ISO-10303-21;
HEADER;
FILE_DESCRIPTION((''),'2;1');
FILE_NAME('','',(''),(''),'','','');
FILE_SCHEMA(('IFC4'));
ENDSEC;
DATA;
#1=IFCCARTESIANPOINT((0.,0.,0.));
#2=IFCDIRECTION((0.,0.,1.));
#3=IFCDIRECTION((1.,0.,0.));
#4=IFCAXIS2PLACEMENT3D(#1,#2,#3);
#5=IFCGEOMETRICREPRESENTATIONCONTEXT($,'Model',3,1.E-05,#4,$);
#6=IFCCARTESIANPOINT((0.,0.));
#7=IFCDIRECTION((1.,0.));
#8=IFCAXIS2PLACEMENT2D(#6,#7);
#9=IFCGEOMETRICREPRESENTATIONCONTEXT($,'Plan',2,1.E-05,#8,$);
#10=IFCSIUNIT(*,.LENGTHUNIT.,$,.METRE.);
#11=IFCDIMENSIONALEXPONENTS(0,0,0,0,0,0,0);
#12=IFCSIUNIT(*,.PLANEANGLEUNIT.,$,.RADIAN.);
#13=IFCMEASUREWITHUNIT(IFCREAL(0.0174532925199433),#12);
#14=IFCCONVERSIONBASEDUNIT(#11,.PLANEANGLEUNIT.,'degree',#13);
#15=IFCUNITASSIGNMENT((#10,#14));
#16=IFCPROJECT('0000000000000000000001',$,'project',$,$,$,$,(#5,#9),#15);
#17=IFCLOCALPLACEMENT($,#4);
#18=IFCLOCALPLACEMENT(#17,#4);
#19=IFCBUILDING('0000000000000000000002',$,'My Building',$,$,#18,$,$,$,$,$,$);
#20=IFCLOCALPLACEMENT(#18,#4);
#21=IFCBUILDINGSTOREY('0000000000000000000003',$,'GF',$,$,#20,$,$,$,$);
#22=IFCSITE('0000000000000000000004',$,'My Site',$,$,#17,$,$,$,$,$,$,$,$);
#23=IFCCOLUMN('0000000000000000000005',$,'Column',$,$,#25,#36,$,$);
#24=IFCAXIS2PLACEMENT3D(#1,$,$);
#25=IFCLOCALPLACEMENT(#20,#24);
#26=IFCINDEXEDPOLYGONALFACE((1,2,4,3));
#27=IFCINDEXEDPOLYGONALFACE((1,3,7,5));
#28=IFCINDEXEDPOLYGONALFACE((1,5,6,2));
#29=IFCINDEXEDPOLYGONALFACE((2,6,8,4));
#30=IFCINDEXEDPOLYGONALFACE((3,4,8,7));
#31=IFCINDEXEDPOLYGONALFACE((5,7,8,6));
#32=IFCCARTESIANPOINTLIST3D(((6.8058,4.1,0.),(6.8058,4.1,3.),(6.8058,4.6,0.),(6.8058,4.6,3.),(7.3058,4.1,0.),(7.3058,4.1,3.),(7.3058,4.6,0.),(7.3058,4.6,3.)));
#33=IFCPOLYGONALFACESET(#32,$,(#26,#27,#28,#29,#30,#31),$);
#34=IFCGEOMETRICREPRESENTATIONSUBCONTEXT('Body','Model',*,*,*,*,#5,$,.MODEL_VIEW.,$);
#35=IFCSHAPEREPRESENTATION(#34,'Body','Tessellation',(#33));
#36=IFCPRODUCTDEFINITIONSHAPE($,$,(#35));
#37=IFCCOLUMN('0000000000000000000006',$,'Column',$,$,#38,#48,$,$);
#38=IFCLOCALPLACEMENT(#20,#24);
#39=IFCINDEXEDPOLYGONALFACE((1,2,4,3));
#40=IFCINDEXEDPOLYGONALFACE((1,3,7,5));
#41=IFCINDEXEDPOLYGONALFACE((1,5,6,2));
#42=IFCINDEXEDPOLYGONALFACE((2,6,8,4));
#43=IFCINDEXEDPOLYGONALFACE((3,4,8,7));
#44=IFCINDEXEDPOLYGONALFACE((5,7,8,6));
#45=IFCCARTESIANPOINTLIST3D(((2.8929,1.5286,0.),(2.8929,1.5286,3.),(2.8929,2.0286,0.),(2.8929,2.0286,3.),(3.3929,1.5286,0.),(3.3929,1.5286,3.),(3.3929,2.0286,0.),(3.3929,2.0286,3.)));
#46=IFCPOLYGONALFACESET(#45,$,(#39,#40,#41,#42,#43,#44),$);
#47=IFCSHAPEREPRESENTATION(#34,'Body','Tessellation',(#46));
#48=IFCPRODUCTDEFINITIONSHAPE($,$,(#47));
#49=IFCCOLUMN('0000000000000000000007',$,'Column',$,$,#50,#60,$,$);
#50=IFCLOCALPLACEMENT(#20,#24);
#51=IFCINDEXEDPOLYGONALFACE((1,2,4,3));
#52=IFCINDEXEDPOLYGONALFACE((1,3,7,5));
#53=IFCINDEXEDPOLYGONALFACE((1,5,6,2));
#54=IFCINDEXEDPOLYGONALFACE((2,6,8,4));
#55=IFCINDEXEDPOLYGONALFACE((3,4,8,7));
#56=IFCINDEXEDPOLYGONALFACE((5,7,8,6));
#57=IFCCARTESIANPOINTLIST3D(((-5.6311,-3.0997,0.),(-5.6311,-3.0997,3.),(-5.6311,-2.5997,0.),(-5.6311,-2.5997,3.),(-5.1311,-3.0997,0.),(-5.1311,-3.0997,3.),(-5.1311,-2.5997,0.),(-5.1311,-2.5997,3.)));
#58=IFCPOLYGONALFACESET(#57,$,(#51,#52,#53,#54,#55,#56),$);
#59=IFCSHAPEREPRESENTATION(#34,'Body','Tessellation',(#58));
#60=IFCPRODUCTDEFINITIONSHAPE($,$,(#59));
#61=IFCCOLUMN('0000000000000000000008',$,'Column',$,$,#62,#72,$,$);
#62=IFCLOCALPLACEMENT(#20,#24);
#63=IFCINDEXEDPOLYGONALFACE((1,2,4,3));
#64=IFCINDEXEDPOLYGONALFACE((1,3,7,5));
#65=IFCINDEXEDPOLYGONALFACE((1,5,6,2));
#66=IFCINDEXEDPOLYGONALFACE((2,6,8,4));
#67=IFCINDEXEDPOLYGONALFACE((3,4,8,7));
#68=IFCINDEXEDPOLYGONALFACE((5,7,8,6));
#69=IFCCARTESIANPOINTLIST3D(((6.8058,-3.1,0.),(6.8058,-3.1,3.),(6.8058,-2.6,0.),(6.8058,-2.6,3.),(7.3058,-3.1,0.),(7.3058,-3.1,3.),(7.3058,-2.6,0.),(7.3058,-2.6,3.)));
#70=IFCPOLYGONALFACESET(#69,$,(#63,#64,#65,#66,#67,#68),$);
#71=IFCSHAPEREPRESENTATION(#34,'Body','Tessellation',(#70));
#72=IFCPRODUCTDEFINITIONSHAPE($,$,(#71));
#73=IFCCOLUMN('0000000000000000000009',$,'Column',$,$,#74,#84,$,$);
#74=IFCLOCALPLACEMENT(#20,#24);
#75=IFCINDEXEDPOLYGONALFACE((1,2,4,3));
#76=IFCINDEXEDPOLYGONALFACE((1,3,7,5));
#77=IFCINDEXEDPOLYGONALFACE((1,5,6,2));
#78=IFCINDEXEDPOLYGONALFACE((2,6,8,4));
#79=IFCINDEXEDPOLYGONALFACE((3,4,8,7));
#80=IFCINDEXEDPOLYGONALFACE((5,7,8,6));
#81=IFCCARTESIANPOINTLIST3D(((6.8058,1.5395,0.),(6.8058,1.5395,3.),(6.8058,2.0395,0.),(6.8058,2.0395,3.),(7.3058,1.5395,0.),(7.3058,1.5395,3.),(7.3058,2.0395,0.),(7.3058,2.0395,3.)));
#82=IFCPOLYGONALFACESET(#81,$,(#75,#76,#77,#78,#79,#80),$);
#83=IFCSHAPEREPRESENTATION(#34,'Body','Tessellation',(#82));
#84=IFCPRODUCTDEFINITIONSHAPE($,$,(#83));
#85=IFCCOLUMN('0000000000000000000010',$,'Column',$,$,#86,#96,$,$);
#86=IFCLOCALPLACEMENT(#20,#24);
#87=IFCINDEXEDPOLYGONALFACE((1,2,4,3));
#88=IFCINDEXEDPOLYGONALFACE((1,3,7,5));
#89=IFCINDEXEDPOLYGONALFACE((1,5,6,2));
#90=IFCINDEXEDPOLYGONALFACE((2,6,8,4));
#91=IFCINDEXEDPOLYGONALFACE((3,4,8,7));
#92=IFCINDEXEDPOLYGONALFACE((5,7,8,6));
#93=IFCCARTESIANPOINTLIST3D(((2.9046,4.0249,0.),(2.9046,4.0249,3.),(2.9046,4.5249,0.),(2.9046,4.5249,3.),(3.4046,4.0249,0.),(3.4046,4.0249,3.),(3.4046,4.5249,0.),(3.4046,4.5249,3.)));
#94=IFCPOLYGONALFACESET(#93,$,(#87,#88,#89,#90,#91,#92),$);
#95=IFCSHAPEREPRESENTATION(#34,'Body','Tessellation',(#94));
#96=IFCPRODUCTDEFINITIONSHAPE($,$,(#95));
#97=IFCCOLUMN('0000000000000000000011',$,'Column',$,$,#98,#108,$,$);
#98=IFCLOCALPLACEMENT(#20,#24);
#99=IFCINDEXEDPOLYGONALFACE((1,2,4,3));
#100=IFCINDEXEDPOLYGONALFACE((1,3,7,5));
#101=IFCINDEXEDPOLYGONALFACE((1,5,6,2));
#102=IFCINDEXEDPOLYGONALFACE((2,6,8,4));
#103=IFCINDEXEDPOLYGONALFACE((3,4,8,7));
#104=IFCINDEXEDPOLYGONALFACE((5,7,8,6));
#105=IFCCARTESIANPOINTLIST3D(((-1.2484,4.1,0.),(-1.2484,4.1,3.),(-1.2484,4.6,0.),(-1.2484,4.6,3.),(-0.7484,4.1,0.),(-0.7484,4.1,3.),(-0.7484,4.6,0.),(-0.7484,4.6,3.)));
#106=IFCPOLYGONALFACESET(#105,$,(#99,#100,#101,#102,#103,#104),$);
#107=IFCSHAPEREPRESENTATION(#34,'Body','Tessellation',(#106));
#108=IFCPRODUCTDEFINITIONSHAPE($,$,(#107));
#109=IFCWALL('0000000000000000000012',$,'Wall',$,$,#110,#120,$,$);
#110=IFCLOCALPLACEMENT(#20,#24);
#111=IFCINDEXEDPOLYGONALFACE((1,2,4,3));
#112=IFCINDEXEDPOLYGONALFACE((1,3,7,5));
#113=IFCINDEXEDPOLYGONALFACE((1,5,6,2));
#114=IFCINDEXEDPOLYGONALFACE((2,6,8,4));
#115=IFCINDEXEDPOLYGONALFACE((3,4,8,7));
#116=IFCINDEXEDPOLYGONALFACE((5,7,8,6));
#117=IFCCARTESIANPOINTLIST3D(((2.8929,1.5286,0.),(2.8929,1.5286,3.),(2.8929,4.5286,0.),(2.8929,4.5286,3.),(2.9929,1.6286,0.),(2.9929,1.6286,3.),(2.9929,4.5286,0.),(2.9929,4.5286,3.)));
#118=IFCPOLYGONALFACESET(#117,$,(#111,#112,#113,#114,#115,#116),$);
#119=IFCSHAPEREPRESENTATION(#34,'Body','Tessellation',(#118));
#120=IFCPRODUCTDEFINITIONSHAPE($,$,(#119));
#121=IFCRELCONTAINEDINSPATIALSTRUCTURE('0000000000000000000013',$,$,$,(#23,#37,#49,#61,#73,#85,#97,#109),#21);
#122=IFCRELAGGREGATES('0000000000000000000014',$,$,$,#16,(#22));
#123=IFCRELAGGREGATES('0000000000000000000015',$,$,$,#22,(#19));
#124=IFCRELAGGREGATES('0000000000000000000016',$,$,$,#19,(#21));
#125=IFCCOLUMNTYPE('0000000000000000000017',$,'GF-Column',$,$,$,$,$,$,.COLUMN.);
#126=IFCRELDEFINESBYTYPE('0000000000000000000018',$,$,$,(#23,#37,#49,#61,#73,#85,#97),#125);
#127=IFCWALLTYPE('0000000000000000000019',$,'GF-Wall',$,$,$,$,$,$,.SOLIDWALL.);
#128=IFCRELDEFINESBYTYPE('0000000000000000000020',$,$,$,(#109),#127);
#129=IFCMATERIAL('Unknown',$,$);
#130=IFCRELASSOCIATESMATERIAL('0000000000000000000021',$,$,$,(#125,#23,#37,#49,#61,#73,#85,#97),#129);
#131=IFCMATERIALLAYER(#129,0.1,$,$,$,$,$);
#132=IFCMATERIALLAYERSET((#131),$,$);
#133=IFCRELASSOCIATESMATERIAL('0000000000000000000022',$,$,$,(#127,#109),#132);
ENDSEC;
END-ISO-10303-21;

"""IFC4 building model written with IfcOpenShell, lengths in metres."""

from ifc_helpers import new_model, entity, si_unit, converted_unit, frame, origin_with_axes, origin_2d_with_axis, place, context, subcontext, project, spatial, line, indexed_curve, rectangle, outline, extrude, material, layer, layer_set, layer_usage, material_profile, profile_set, profile_usage, type_object, element, save


model = new_model("IFC4")

# Units and contexts
model_context = context("Model", 3, precision=1e-05, world=origin_with_axes())
plan_context = context("Plan", 2, precision=1e-05, world=origin_2d_with_axis())
body_context_1 = subcontext(model_context, "Body", "Model", "MODEL_VIEW")
ifc_project = project(units=[si_unit("LENGTHUNIT", "METRE"), converted_unit("PLANEANGLEUNIT", "degree", entity("IfcReal", 0.0174532925199433), si_unit("PLANEANGLEUNIT", "RADIAN"), dimensions=[0, 0, 0, 0, 0, 0, 0])], contexts=[model_context, plan_context])

# Site, building, storey
site_placement = place(None, origin_with_axes())
site = spatial("IfcSite", under=ifc_project, at=site_placement, Name="My Site")
building_placement = place(site_placement, origin_with_axes())
building = spatial("IfcBuilding", under=site, at=building_placement, Name="My Building")
storey_placement = place(building_placement, origin_with_axes())
storey = spatial("IfcBuildingStorey", under=building, at=storey_placement, Name="GF")

# Columns
ifc_material = material(Name="Unknown")
ifc_material_profile = material_profile(ifc_material, rectangle(XDim=0.5, YDim=0.5))
ifc_profile_set = profile_set([ifc_material_profile])
ifc_profile_usage_1 = profile_usage(ifc_profile_set, cardinal=7)
column_type = type_object("IfcColumnType", Name="GF-Column", PredefinedType="COLUMN", material=ifc_profile_set)
column_1_placement = place(storey_placement, frame((7.3058, 4.6, 0.0), z_axis=(0.0, 0.0, 1.0), x_axis=(1.0, 0.0, 0.0)))
element("IfcColumn", 1, at=column_1_placement, inside=storey, type_object=column_type, material=ifc_profile_usage_1, Name="Column", context=body_context_1, shape_type="SweptSolid", body=[
    extrude(rectangle(XDim=0.5, YDim=0.5), frame((-0.25, -0.25, 0.0), z_axis=(0.0, 0.0, 1.0), x_axis=(1.0, 0.0, 0.0)), (0.0, 0.0, 1.0), 3.0),
])
ifc_profile_usage_2 = profile_usage(ifc_profile_set, cardinal=3)
column_2_placement = place(storey_placement, frame((2.8929, 1.5286, 0.0), z_axis=(0.0, 0.0, 1.0), x_axis=(1.0, 0.0, 0.0)))
element("IfcColumn", 2, at=column_2_placement, inside=storey, type_object=column_type, material=ifc_profile_usage_2, Name="Column", context=body_context_1, shape_type="SweptSolid", body=[
    extrude(rectangle(XDim=0.5, YDim=0.5), frame((0.25, 0.25, 0.0), z_axis=(0.0, 0.0, 1.0), x_axis=(1.0, 0.0, 0.0)), (0.0, 0.0, 1.0), 3.0),
])
ifc_profile_usage_3 = profile_usage(ifc_profile_set, cardinal=1)
column_3_placement = place(storey_placement, frame((-5.1311, -3.0997, 0.0), z_axis=(0.0, 0.0, 1.0), x_axis=(1.0, 0.0, 0.0)))
element("IfcColumn", 3, at=column_3_placement, inside=storey, type_object=column_type, material=ifc_profile_usage_3, Name="Column", context=body_context_1, shape_type="SweptSolid", body=[
    extrude(rectangle(XDim=0.5, YDim=0.5), frame((-0.25, 0.25, 0.0), z_axis=(0.0, 0.0, 1.0), x_axis=(1.0, 0.0, 0.0)), (0.0, 0.0, 1.0), 3.0),
])
ifc_profile_usage_4 = profile_usage(ifc_profile_set, cardinal=1)
column_4_placement = place(storey_placement, frame((7.3058, -3.1, 0.0), z_axis=(0.0, 0.0, 1.0), x_axis=(1.0, 0.0, 0.0)))
element("IfcColumn", 4, at=column_4_placement, inside=storey, type_object=column_type, material=ifc_profile_usage_4, Name="Column", context=body_context_1, shape_type="SweptSolid", body=[
    extrude(rectangle(XDim=0.5, YDim=0.5), frame((-0.25, 0.25, 0.0), z_axis=(0.0, 0.0, 1.0), x_axis=(1.0, 0.0, 0.0)), (0.0, 0.0, 1.0), 3.0),
])
ifc_profile_usage_5 = profile_usage(ifc_profile_set, cardinal=1)
column_5_placement = place(storey_placement, frame((7.3058, 1.5395, 0.0), z_axis=(0.0, 0.0, 1.0), x_axis=(1.0, 0.0, 0.0)))
element("IfcColumn", 5, at=column_5_placement, inside=storey, type_object=column_type, material=ifc_profile_usage_5, Name="Column", context=body_context_1, shape_type="SweptSolid", body=[
    extrude(rectangle(XDim=0.5, YDim=0.5), frame((-0.25, 0.25, 0.0), z_axis=(0.0, 0.0, 1.0), x_axis=(1.0, 0.0, 0.0)), (0.0, 0.0, 1.0), 3.0),
])
ifc_profile_usage_6 = profile_usage(ifc_profile_set, cardinal=9)
column_6_placement = place(storey_placement, frame((2.9046, 4.5249, 0.0), z_axis=(0.0, 0.0, 1.0), x_axis=(1.0, 0.0, 0.0)))
element("IfcColumn", 6, at=column_6_placement, inside=storey, type_object=column_type, material=ifc_profile_usage_6, Name="Column", context=body_context_1, shape_type="SweptSolid", body=[
    extrude(rectangle(XDim=0.5, YDim=0.5), frame((0.25, -0.25, 0.0), z_axis=(0.0, 0.0, 1.0), x_axis=(1.0, 0.0, 0.0)), (0.0, 0.0, 1.0), 3.0),
])
ifc_profile_usage_7 = profile_usage(ifc_profile_set, cardinal=8)
column_7_placement = place(storey_placement, frame((-0.9984, 4.6, 0.0), z_axis=(0.0, 0.0, 1.0), x_axis=(1.0, 0.0, 0.0)))
element("IfcColumn", 7, at=column_7_placement, inside=storey, type_object=column_type, material=ifc_profile_usage_7, Name="Column", context=body_context_1, shape_type="SweptSolid", body=[
    extrude(rectangle(XDim=0.5, YDim=0.5), frame((0.0, -0.25, 0.0), z_axis=(0.0, 0.0, 1.0), x_axis=(1.0, 0.0, 0.0)), (0.0, 0.0, 1.0), 3.0),
])

# Shared definitions
ifc_layer = layer(ifc_material, 0.1)
ifc_layer_set = layer_set([ifc_layer])
wall_type = type_object("IfcWallType", Name="GF-Wall", PredefinedType="SOLIDWALL", material=ifc_layer_set)

# Wall
ifc_layer_usage_1 = layer_usage(ifc_layer_set, "AXIS2", "POSITIVE", 0.0)
wall_1_placement = place(storey_placement, frame((2.8929, 4.5286, 0.0), z_axis=(0.0, 0.0, 1.0), x_axis=(0.0, -1.0, 0.0)))
element("IfcWall", 8, at=wall_1_placement, inside=storey, type_object=wall_type, material=ifc_layer_usage_1, Name="Wall", context=body_context_1, shape_type="SweptSolid", body=[
    extrude(outline(indexed_curve([(0.0, 0.0), (0.0, 0.1), (2.9, 0.1), (3.0, 0.0)], segments=[line(1, 2, 3, 4, 1)])), origin_with_axes(), (0.0, 0.0, 1.0), 3.0),
])

save(model, "model.ifc")
